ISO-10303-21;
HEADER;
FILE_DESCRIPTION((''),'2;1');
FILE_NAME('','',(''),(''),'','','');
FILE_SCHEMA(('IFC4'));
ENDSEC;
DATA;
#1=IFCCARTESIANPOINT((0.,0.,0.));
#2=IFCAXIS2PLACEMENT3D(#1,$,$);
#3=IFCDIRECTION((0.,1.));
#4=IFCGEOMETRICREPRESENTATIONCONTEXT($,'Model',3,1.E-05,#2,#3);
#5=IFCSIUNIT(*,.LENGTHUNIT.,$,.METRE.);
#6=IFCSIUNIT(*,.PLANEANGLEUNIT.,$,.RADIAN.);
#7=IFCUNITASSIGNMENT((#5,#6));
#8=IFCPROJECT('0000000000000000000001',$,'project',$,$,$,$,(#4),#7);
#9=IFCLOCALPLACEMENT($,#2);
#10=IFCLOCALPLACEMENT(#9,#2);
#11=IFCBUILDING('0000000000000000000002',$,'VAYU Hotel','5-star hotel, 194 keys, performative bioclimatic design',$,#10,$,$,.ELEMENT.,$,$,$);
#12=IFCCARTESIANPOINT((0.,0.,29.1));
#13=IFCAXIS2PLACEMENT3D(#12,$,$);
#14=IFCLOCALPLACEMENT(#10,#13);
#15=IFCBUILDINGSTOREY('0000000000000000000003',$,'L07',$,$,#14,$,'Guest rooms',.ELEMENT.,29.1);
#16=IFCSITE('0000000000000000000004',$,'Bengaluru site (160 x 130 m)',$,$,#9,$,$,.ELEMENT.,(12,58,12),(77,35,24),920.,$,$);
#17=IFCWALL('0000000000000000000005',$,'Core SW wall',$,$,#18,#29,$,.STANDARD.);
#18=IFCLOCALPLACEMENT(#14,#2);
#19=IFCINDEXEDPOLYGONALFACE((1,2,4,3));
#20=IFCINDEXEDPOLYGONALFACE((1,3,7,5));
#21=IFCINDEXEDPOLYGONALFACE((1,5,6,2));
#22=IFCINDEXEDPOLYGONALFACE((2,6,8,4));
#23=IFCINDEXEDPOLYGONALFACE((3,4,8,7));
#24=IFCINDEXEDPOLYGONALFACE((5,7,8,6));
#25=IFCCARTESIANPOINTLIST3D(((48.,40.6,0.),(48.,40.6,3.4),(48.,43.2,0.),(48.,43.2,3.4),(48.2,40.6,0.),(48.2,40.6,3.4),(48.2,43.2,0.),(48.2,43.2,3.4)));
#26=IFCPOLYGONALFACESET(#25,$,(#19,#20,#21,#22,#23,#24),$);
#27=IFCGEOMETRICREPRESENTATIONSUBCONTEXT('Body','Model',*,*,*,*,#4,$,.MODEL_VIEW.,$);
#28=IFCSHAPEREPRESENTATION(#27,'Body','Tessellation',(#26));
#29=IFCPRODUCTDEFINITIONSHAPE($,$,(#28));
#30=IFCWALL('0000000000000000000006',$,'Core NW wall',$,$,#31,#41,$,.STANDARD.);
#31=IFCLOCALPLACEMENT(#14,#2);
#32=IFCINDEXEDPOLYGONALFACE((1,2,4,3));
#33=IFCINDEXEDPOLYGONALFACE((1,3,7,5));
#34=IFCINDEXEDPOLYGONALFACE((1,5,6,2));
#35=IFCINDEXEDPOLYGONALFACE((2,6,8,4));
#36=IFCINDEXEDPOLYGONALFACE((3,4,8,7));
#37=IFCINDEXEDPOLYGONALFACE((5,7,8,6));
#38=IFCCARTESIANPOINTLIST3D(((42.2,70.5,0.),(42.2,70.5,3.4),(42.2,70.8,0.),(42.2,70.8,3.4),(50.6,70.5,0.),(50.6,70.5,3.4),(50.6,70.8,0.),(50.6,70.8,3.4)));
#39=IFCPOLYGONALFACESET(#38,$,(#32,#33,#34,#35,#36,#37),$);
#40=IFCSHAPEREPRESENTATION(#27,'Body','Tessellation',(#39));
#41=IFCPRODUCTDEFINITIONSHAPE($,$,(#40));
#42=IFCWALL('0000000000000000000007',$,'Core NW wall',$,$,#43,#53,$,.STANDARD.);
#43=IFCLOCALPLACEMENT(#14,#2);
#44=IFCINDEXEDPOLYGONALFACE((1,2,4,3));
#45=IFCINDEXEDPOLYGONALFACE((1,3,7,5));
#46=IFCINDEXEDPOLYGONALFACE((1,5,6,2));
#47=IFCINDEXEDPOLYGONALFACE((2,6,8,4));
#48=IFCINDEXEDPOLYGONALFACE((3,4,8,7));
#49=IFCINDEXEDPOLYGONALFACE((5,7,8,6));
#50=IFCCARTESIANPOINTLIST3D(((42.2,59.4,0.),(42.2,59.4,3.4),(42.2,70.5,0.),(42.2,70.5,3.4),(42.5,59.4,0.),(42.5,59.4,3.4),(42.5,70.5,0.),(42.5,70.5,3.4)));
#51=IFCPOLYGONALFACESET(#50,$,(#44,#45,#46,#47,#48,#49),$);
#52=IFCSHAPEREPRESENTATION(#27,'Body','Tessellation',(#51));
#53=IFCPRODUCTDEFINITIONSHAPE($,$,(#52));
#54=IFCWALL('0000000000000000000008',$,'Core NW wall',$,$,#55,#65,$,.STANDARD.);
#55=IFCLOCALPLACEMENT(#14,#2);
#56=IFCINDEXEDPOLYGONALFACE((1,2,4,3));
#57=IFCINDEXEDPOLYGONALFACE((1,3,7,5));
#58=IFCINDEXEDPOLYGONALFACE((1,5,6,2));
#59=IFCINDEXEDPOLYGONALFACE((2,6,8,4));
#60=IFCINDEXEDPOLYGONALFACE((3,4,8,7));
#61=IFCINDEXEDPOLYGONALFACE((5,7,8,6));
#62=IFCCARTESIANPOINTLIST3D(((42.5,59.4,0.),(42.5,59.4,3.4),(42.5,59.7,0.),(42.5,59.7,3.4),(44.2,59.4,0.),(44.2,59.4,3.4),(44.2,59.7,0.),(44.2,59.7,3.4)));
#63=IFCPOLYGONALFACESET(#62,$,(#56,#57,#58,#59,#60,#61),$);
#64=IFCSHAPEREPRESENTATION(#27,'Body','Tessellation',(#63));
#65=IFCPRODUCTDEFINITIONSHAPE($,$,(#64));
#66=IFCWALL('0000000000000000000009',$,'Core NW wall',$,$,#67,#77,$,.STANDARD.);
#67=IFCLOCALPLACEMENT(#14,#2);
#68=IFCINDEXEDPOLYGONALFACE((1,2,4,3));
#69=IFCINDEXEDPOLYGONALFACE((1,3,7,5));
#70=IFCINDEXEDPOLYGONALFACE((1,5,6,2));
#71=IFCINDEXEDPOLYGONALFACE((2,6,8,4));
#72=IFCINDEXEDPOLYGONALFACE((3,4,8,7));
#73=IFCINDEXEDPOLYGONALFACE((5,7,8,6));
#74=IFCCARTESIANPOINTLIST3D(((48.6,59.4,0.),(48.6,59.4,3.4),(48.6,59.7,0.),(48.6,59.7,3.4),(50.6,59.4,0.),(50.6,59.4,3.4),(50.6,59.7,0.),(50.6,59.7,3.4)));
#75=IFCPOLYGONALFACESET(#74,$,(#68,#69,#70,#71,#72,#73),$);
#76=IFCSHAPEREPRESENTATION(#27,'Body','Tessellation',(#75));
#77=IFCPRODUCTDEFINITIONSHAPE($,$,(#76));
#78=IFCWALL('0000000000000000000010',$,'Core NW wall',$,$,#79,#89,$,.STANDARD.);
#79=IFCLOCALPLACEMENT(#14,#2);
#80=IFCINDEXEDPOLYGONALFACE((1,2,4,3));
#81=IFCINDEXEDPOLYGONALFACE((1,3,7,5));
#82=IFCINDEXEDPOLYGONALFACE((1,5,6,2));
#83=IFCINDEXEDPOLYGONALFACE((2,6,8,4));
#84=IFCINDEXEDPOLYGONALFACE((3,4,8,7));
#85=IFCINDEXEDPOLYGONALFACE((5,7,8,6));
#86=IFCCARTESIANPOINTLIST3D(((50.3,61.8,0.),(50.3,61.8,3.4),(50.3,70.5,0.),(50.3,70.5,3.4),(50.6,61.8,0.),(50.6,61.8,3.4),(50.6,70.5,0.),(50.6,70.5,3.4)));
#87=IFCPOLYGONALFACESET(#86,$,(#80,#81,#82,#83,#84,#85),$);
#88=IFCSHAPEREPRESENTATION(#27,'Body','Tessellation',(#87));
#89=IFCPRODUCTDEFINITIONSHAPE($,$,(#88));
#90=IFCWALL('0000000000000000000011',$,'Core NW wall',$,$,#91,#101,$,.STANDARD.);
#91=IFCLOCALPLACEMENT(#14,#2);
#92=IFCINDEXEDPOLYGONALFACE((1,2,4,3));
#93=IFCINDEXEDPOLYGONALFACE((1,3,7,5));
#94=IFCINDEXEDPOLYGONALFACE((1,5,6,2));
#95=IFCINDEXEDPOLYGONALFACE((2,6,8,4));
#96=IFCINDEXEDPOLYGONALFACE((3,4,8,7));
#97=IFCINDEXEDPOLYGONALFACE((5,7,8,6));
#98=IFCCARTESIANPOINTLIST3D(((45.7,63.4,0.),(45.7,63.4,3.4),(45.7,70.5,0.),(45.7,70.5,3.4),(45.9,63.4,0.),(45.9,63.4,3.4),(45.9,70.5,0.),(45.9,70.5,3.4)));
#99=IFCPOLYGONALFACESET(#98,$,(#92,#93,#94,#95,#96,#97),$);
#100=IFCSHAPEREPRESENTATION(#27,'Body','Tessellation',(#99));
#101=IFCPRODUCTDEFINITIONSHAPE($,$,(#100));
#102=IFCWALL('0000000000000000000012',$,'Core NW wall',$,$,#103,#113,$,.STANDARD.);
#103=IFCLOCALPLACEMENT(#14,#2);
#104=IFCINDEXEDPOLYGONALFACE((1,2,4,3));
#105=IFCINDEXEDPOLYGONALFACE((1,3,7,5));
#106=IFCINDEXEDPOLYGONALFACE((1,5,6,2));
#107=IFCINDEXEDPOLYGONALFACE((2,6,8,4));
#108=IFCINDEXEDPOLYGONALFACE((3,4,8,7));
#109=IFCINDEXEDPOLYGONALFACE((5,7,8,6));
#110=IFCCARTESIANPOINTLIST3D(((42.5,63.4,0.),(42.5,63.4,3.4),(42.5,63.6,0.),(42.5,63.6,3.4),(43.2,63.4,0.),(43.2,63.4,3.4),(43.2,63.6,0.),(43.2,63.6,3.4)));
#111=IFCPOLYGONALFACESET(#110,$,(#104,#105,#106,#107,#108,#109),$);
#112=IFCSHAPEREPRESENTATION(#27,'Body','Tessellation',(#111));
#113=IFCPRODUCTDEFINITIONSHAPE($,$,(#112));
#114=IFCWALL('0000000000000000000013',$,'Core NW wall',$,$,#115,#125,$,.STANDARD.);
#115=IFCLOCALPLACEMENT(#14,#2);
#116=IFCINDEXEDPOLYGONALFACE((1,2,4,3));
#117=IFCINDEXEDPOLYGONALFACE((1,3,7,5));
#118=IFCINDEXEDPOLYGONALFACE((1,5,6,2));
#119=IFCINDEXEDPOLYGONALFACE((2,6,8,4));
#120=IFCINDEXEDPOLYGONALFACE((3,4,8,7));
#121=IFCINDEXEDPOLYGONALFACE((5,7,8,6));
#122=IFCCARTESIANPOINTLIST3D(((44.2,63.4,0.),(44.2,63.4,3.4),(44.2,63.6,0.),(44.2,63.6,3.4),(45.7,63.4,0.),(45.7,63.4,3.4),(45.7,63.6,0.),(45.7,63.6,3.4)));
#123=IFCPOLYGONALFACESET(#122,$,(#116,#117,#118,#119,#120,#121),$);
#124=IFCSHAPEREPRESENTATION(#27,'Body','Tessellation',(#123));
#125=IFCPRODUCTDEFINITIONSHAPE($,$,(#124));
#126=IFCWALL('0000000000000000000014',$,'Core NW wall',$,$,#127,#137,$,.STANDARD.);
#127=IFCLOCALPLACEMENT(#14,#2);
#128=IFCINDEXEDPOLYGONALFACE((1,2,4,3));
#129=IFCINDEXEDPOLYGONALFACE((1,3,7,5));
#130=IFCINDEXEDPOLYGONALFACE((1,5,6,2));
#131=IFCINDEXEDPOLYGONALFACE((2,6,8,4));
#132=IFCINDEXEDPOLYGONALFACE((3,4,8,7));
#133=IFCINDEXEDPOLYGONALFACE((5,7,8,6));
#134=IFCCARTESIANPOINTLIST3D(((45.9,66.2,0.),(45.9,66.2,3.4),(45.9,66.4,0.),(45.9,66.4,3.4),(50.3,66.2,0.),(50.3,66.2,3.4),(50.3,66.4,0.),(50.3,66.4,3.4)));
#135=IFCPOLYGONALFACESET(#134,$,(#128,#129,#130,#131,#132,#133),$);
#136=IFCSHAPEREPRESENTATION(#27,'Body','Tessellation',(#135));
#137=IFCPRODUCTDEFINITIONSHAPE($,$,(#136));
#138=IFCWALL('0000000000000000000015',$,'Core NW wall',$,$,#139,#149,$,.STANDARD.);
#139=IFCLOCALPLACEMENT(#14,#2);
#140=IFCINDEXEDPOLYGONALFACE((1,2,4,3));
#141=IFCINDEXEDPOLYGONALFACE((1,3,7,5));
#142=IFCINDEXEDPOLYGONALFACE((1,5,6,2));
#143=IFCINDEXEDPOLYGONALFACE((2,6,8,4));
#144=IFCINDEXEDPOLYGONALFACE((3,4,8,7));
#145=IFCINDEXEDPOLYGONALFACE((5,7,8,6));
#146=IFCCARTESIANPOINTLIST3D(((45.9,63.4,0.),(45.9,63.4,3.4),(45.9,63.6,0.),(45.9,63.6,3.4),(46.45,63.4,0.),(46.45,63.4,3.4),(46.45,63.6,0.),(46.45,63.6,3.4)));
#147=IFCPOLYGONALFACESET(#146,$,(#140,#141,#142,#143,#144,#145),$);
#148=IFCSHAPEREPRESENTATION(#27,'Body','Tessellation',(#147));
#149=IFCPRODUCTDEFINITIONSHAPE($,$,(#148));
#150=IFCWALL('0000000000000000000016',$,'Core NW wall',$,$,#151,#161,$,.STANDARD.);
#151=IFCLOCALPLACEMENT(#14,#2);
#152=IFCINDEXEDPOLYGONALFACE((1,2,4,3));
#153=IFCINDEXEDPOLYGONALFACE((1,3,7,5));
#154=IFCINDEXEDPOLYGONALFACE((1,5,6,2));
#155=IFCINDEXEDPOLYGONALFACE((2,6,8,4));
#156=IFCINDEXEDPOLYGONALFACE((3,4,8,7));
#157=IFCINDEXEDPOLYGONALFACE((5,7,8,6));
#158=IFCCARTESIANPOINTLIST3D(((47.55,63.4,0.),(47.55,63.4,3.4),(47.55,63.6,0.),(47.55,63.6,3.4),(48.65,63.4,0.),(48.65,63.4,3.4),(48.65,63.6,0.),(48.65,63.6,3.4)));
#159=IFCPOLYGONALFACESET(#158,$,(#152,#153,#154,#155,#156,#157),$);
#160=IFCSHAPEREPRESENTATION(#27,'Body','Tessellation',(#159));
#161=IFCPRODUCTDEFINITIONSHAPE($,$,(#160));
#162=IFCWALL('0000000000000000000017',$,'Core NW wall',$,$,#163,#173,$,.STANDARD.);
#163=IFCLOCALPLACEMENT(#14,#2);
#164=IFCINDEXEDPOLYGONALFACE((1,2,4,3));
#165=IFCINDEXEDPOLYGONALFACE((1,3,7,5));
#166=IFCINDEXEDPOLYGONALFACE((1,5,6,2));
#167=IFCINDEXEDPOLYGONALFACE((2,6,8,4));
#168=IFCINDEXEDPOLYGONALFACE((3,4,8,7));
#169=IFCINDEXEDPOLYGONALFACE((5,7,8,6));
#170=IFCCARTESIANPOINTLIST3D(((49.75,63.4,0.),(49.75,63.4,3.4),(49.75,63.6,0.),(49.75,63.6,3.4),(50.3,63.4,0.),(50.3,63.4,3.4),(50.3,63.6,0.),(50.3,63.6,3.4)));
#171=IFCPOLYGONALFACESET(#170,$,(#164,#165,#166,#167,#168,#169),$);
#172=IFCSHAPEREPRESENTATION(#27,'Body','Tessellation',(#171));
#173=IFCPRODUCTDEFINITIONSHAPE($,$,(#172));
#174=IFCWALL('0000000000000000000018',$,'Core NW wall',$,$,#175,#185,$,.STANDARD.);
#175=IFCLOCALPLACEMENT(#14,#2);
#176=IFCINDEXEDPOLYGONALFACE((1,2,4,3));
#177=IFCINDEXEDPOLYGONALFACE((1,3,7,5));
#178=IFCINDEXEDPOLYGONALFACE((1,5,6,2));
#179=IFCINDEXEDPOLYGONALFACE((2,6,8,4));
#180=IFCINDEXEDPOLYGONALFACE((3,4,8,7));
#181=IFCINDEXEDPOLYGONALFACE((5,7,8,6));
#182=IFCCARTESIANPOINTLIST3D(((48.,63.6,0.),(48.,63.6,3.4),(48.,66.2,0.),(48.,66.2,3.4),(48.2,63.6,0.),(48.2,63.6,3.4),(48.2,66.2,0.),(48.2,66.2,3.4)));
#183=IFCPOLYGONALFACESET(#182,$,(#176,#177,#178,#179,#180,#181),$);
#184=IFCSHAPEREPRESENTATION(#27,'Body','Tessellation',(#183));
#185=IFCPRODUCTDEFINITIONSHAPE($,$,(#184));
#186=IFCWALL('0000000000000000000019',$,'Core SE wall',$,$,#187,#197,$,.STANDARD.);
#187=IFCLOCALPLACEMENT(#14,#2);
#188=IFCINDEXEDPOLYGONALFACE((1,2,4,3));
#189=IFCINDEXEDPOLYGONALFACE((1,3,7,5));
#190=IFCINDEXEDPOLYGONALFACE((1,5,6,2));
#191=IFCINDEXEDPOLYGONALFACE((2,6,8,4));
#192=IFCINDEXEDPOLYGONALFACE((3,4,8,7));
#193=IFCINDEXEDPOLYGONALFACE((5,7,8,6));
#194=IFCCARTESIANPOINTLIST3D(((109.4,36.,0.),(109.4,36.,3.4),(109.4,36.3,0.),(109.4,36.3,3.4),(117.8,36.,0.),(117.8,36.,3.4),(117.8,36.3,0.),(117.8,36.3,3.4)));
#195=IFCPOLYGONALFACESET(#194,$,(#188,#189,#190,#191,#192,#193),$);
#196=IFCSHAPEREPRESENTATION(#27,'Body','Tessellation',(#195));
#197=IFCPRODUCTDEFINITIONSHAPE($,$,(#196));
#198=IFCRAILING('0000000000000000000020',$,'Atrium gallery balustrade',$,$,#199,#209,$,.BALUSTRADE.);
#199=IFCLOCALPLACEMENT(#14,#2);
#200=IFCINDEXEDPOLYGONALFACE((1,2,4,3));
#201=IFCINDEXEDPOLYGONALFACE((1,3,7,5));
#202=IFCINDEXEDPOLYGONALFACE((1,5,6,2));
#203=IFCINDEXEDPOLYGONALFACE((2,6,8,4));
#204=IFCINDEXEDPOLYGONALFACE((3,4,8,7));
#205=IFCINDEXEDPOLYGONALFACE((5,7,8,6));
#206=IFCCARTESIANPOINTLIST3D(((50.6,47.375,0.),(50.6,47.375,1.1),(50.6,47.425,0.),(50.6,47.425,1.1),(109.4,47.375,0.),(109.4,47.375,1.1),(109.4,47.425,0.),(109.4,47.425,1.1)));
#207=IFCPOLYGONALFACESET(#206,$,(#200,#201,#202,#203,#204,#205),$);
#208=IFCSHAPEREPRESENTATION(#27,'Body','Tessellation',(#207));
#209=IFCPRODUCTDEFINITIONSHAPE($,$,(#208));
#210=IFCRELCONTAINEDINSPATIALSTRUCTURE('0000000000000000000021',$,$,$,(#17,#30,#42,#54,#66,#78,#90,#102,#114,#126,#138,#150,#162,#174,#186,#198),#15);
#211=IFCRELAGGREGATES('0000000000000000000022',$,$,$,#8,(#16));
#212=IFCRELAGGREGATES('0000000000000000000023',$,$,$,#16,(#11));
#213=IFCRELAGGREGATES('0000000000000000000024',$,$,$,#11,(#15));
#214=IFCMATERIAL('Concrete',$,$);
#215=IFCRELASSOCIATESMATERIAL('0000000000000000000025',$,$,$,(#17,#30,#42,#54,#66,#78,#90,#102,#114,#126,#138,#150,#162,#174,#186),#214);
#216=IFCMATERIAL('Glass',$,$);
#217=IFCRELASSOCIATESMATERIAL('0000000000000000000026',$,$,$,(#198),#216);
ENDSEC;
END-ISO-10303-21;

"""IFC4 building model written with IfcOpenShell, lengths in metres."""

from ifc_helpers import new_model, si_unit, direction, frame, origin, place, context, subcontext, project, spatial, polyline, outline, extrude, material, element, save


model = new_model("IFC4")

# Units and contexts
model_context = context("Model", 3, precision=1e-05, world=origin(), true_north=direction((0.0, 1.0)))
body_context = subcontext(model_context, "Body", "Model", "MODEL_VIEW")
ifc_project = project(units=[si_unit("LENGTHUNIT", "METRE"), si_unit("PLANEANGLEUNIT", "RADIAN")], contexts=[model_context])

# Site, building, storey
site_placement = place(None, origin())
site = spatial("IfcSite", under=ifc_project, at=site_placement, Name="Bengaluru site (160 x 130 m)", CompositionType="ELEMENT", RefLatitude=(12, 58, 12), RefLongitude=(77, 35, 24), RefElevation=920.0)
building_placement = place(site_placement, origin())
building = spatial("IfcBuilding", under=site, at=building_placement, Name="VAYU Hotel", Description="5-star hotel, 194 keys, performative bioclimatic design", CompositionType="ELEMENT")
storey_placement = place(building_placement, frame((0.0, 0.0, 29.1)))
storey = spatial("IfcBuildingStorey", under=building, at=storey_placement, Name="L07", LongName="Guest rooms", CompositionType="ELEMENT", Elevation=29.1)

# Shared definitions
ifc_material_1 = material(Name="Concrete")

# Walls
wall_1_placement = place(storey_placement, origin())
element("IfcWall", 1, at=wall_1_placement, inside=storey, material=ifc_material_1, Name="Core SW wall", PredefinedType="STANDARD", context=body_context, shape_type="SweptSolid", body=[
    extrude(outline(polyline([(48.0, 40.6), (48.0, 43.2), (48.2, 43.2), (48.2, 40.6), (48.0, 40.6)])), origin(), (0.0, 0.0, 1.0), 3.4),
])
wall_2_placement = place(storey_placement, origin())
element("IfcWall", 2, at=wall_2_placement, inside=storey, material=ifc_material_1, Name="Core NW wall", PredefinedType="STANDARD", context=body_context, shape_type="SweptSolid", body=[
    extrude(outline(polyline([(42.2, 70.8), (50.6, 70.8), (50.6, 70.5), (42.2, 70.5), (42.2, 70.8)])), origin(), (0.0, 0.0, 1.0), 3.4),
])
wall_3_placement = place(storey_placement, origin())
element("IfcWall", 3, at=wall_3_placement, inside=storey, material=ifc_material_1, Name="Core NW wall", PredefinedType="STANDARD", context=body_context, shape_type="SweptSolid", body=[
    extrude(outline(polyline([(42.2, 59.4), (42.2, 70.5), (42.5, 70.5), (42.5, 59.4), (42.2, 59.4)])), origin(), (0.0, 0.0, 1.0), 3.4),
])
wall_4_placement = place(storey_placement, origin())
element("IfcWall", 4, at=wall_4_placement, inside=storey, material=ifc_material_1, Name="Core NW wall", PredefinedType="STANDARD", context=body_context, shape_type="SweptSolid", body=[
    extrude(outline(polyline([(42.5, 59.7), (44.2, 59.7), (44.2, 59.4), (42.5, 59.4), (42.5, 59.7)])), origin(), (0.0, 0.0, 1.0), 3.4),
])
wall_5_placement = place(storey_placement, origin())
element("IfcWall", 5, at=wall_5_placement, inside=storey, material=ifc_material_1, Name="Core NW wall", PredefinedType="STANDARD", context=body_context, shape_type="SweptSolid", body=[
    extrude(outline(polyline([(48.6, 59.7), (50.6, 59.7), (50.6, 59.4), (48.6, 59.4), (48.6, 59.7)])), origin(), (0.0, 0.0, 1.0), 3.4),
])
wall_6_placement = place(storey_placement, origin())
element("IfcWall", 6, at=wall_6_placement, inside=storey, material=ifc_material_1, Name="Core NW wall", PredefinedType="STANDARD", context=body_context, shape_type="SweptSolid", body=[
    extrude(outline(polyline([(50.3, 61.8), (50.3, 70.5), (50.6, 70.5), (50.6, 61.8), (50.3, 61.8)])), origin(), (0.0, 0.0, 1.0), 3.4),
])
wall_7_placement = place(storey_placement, origin())
element("IfcWall", 7, at=wall_7_placement, inside=storey, material=ifc_material_1, Name="Core NW wall", PredefinedType="STANDARD", context=body_context, shape_type="SweptSolid", body=[
    extrude(outline(polyline([(45.7, 63.4), (45.7, 70.5), (45.9, 70.5), (45.9, 63.4), (45.7, 63.4)])), origin(), (0.0, 0.0, 1.0), 3.4),
])
wall_8_placement = place(storey_placement, origin())
element("IfcWall", 8, at=wall_8_placement, inside=storey, material=ifc_material_1, Name="Core NW wall", PredefinedType="STANDARD", context=body_context, shape_type="SweptSolid", body=[
    extrude(outline(polyline([(42.5, 63.6), (43.2, 63.6), (43.2, 63.4), (42.5, 63.4), (42.5, 63.6)])), origin(), (0.0, 0.0, 1.0), 3.4),
])
wall_9_placement = place(storey_placement, origin())
element("IfcWall", 9, at=wall_9_placement, inside=storey, material=ifc_material_1, Name="Core NW wall", PredefinedType="STANDARD", context=body_context, shape_type="SweptSolid", body=[
    extrude(outline(polyline([(44.2, 63.6), (45.7, 63.6), (45.7, 63.4), (44.2, 63.4), (44.2, 63.6)])), origin(), (0.0, 0.0, 1.0), 3.4),
])
wall_10_placement = place(storey_placement, origin())
element("IfcWall", 10, at=wall_10_placement, inside=storey, material=ifc_material_1, Name="Core NW wall", PredefinedType="STANDARD", context=body_context, shape_type="SweptSolid", body=[
    extrude(outline(polyline([(45.9, 66.4), (50.3, 66.4), (50.3, 66.2), (45.9, 66.2), (45.9, 66.4)])), origin(), (0.0, 0.0, 1.0), 3.4),
])
wall_11_placement = place(storey_placement, origin())
element("IfcWall", 11, at=wall_11_placement, inside=storey, material=ifc_material_1, Name="Core NW wall", PredefinedType="STANDARD", context=body_context, shape_type="SweptSolid", body=[
    extrude(outline(polyline([(45.9, 63.6), (46.45, 63.6), (46.45, 63.4), (45.9, 63.4), (45.9, 63.6)])), origin(), (0.0, 0.0, 1.0), 3.4),
])
wall_12_placement = place(storey_placement, origin())
element("IfcWall", 12, at=wall_12_placement, inside=storey, material=ifc_material_1, Name="Core NW wall", PredefinedType="STANDARD", context=body_context, shape_type="SweptSolid", body=[
    extrude(outline(polyline([(47.55, 63.6), (48.65, 63.6), (48.65, 63.4), (47.55, 63.4), (47.55, 63.6)])), origin(), (0.0, 0.0, 1.0), 3.4),
])
wall_13_placement = place(storey_placement, origin())
element("IfcWall", 13, at=wall_13_placement, inside=storey, material=ifc_material_1, Name="Core NW wall", PredefinedType="STANDARD", context=body_context, shape_type="SweptSolid", body=[
    extrude(outline(polyline([(49.75, 63.6), (50.3, 63.6), (50.3, 63.4), (49.75, 63.4), (49.75, 63.6)])), origin(), (0.0, 0.0, 1.0), 3.4),
])
wall_14_placement = place(storey_placement, origin())
element("IfcWall", 14, at=wall_14_placement, inside=storey, material=ifc_material_1, Name="Core NW wall", PredefinedType="STANDARD", context=body_context, shape_type="SweptSolid", body=[
    extrude(outline(polyline([(48.0, 63.6), (48.0, 66.2), (48.2, 66.2), (48.2, 63.6), (48.0, 63.6)])), origin(), (0.0, 0.0, 1.0), 3.4),
])
wall_15_placement = place(storey_placement, origin())
element("IfcWall", 15, at=wall_15_placement, inside=storey, material=ifc_material_1, Name="Core SE wall", PredefinedType="STANDARD", context=body_context, shape_type="SweptSolid", body=[
    extrude(outline(polyline([(109.4, 36.3), (117.8, 36.3), (117.8, 36.0), (109.4, 36.0), (109.4, 36.3)])), origin(), (0.0, 0.0, 1.0), 3.4),
])

# Railing
ifc_material_2 = material(Name="Glass")
railing_1_placement = place(storey_placement, origin())
element("IfcRailing", 16, at=railing_1_placement, inside=storey, material=ifc_material_2, Name="Atrium gallery balustrade", PredefinedType="BALUSTRADE", context=body_context, shape_type="SweptSolid", body=[
    extrude(outline(polyline([(50.6, 47.425), (109.4, 47.425), (109.4, 47.375), (50.6, 47.375), (50.6, 47.425)])), origin(), (0.0, 0.0, 1.0), 1.1),
])

save(model, "model.ifc")
